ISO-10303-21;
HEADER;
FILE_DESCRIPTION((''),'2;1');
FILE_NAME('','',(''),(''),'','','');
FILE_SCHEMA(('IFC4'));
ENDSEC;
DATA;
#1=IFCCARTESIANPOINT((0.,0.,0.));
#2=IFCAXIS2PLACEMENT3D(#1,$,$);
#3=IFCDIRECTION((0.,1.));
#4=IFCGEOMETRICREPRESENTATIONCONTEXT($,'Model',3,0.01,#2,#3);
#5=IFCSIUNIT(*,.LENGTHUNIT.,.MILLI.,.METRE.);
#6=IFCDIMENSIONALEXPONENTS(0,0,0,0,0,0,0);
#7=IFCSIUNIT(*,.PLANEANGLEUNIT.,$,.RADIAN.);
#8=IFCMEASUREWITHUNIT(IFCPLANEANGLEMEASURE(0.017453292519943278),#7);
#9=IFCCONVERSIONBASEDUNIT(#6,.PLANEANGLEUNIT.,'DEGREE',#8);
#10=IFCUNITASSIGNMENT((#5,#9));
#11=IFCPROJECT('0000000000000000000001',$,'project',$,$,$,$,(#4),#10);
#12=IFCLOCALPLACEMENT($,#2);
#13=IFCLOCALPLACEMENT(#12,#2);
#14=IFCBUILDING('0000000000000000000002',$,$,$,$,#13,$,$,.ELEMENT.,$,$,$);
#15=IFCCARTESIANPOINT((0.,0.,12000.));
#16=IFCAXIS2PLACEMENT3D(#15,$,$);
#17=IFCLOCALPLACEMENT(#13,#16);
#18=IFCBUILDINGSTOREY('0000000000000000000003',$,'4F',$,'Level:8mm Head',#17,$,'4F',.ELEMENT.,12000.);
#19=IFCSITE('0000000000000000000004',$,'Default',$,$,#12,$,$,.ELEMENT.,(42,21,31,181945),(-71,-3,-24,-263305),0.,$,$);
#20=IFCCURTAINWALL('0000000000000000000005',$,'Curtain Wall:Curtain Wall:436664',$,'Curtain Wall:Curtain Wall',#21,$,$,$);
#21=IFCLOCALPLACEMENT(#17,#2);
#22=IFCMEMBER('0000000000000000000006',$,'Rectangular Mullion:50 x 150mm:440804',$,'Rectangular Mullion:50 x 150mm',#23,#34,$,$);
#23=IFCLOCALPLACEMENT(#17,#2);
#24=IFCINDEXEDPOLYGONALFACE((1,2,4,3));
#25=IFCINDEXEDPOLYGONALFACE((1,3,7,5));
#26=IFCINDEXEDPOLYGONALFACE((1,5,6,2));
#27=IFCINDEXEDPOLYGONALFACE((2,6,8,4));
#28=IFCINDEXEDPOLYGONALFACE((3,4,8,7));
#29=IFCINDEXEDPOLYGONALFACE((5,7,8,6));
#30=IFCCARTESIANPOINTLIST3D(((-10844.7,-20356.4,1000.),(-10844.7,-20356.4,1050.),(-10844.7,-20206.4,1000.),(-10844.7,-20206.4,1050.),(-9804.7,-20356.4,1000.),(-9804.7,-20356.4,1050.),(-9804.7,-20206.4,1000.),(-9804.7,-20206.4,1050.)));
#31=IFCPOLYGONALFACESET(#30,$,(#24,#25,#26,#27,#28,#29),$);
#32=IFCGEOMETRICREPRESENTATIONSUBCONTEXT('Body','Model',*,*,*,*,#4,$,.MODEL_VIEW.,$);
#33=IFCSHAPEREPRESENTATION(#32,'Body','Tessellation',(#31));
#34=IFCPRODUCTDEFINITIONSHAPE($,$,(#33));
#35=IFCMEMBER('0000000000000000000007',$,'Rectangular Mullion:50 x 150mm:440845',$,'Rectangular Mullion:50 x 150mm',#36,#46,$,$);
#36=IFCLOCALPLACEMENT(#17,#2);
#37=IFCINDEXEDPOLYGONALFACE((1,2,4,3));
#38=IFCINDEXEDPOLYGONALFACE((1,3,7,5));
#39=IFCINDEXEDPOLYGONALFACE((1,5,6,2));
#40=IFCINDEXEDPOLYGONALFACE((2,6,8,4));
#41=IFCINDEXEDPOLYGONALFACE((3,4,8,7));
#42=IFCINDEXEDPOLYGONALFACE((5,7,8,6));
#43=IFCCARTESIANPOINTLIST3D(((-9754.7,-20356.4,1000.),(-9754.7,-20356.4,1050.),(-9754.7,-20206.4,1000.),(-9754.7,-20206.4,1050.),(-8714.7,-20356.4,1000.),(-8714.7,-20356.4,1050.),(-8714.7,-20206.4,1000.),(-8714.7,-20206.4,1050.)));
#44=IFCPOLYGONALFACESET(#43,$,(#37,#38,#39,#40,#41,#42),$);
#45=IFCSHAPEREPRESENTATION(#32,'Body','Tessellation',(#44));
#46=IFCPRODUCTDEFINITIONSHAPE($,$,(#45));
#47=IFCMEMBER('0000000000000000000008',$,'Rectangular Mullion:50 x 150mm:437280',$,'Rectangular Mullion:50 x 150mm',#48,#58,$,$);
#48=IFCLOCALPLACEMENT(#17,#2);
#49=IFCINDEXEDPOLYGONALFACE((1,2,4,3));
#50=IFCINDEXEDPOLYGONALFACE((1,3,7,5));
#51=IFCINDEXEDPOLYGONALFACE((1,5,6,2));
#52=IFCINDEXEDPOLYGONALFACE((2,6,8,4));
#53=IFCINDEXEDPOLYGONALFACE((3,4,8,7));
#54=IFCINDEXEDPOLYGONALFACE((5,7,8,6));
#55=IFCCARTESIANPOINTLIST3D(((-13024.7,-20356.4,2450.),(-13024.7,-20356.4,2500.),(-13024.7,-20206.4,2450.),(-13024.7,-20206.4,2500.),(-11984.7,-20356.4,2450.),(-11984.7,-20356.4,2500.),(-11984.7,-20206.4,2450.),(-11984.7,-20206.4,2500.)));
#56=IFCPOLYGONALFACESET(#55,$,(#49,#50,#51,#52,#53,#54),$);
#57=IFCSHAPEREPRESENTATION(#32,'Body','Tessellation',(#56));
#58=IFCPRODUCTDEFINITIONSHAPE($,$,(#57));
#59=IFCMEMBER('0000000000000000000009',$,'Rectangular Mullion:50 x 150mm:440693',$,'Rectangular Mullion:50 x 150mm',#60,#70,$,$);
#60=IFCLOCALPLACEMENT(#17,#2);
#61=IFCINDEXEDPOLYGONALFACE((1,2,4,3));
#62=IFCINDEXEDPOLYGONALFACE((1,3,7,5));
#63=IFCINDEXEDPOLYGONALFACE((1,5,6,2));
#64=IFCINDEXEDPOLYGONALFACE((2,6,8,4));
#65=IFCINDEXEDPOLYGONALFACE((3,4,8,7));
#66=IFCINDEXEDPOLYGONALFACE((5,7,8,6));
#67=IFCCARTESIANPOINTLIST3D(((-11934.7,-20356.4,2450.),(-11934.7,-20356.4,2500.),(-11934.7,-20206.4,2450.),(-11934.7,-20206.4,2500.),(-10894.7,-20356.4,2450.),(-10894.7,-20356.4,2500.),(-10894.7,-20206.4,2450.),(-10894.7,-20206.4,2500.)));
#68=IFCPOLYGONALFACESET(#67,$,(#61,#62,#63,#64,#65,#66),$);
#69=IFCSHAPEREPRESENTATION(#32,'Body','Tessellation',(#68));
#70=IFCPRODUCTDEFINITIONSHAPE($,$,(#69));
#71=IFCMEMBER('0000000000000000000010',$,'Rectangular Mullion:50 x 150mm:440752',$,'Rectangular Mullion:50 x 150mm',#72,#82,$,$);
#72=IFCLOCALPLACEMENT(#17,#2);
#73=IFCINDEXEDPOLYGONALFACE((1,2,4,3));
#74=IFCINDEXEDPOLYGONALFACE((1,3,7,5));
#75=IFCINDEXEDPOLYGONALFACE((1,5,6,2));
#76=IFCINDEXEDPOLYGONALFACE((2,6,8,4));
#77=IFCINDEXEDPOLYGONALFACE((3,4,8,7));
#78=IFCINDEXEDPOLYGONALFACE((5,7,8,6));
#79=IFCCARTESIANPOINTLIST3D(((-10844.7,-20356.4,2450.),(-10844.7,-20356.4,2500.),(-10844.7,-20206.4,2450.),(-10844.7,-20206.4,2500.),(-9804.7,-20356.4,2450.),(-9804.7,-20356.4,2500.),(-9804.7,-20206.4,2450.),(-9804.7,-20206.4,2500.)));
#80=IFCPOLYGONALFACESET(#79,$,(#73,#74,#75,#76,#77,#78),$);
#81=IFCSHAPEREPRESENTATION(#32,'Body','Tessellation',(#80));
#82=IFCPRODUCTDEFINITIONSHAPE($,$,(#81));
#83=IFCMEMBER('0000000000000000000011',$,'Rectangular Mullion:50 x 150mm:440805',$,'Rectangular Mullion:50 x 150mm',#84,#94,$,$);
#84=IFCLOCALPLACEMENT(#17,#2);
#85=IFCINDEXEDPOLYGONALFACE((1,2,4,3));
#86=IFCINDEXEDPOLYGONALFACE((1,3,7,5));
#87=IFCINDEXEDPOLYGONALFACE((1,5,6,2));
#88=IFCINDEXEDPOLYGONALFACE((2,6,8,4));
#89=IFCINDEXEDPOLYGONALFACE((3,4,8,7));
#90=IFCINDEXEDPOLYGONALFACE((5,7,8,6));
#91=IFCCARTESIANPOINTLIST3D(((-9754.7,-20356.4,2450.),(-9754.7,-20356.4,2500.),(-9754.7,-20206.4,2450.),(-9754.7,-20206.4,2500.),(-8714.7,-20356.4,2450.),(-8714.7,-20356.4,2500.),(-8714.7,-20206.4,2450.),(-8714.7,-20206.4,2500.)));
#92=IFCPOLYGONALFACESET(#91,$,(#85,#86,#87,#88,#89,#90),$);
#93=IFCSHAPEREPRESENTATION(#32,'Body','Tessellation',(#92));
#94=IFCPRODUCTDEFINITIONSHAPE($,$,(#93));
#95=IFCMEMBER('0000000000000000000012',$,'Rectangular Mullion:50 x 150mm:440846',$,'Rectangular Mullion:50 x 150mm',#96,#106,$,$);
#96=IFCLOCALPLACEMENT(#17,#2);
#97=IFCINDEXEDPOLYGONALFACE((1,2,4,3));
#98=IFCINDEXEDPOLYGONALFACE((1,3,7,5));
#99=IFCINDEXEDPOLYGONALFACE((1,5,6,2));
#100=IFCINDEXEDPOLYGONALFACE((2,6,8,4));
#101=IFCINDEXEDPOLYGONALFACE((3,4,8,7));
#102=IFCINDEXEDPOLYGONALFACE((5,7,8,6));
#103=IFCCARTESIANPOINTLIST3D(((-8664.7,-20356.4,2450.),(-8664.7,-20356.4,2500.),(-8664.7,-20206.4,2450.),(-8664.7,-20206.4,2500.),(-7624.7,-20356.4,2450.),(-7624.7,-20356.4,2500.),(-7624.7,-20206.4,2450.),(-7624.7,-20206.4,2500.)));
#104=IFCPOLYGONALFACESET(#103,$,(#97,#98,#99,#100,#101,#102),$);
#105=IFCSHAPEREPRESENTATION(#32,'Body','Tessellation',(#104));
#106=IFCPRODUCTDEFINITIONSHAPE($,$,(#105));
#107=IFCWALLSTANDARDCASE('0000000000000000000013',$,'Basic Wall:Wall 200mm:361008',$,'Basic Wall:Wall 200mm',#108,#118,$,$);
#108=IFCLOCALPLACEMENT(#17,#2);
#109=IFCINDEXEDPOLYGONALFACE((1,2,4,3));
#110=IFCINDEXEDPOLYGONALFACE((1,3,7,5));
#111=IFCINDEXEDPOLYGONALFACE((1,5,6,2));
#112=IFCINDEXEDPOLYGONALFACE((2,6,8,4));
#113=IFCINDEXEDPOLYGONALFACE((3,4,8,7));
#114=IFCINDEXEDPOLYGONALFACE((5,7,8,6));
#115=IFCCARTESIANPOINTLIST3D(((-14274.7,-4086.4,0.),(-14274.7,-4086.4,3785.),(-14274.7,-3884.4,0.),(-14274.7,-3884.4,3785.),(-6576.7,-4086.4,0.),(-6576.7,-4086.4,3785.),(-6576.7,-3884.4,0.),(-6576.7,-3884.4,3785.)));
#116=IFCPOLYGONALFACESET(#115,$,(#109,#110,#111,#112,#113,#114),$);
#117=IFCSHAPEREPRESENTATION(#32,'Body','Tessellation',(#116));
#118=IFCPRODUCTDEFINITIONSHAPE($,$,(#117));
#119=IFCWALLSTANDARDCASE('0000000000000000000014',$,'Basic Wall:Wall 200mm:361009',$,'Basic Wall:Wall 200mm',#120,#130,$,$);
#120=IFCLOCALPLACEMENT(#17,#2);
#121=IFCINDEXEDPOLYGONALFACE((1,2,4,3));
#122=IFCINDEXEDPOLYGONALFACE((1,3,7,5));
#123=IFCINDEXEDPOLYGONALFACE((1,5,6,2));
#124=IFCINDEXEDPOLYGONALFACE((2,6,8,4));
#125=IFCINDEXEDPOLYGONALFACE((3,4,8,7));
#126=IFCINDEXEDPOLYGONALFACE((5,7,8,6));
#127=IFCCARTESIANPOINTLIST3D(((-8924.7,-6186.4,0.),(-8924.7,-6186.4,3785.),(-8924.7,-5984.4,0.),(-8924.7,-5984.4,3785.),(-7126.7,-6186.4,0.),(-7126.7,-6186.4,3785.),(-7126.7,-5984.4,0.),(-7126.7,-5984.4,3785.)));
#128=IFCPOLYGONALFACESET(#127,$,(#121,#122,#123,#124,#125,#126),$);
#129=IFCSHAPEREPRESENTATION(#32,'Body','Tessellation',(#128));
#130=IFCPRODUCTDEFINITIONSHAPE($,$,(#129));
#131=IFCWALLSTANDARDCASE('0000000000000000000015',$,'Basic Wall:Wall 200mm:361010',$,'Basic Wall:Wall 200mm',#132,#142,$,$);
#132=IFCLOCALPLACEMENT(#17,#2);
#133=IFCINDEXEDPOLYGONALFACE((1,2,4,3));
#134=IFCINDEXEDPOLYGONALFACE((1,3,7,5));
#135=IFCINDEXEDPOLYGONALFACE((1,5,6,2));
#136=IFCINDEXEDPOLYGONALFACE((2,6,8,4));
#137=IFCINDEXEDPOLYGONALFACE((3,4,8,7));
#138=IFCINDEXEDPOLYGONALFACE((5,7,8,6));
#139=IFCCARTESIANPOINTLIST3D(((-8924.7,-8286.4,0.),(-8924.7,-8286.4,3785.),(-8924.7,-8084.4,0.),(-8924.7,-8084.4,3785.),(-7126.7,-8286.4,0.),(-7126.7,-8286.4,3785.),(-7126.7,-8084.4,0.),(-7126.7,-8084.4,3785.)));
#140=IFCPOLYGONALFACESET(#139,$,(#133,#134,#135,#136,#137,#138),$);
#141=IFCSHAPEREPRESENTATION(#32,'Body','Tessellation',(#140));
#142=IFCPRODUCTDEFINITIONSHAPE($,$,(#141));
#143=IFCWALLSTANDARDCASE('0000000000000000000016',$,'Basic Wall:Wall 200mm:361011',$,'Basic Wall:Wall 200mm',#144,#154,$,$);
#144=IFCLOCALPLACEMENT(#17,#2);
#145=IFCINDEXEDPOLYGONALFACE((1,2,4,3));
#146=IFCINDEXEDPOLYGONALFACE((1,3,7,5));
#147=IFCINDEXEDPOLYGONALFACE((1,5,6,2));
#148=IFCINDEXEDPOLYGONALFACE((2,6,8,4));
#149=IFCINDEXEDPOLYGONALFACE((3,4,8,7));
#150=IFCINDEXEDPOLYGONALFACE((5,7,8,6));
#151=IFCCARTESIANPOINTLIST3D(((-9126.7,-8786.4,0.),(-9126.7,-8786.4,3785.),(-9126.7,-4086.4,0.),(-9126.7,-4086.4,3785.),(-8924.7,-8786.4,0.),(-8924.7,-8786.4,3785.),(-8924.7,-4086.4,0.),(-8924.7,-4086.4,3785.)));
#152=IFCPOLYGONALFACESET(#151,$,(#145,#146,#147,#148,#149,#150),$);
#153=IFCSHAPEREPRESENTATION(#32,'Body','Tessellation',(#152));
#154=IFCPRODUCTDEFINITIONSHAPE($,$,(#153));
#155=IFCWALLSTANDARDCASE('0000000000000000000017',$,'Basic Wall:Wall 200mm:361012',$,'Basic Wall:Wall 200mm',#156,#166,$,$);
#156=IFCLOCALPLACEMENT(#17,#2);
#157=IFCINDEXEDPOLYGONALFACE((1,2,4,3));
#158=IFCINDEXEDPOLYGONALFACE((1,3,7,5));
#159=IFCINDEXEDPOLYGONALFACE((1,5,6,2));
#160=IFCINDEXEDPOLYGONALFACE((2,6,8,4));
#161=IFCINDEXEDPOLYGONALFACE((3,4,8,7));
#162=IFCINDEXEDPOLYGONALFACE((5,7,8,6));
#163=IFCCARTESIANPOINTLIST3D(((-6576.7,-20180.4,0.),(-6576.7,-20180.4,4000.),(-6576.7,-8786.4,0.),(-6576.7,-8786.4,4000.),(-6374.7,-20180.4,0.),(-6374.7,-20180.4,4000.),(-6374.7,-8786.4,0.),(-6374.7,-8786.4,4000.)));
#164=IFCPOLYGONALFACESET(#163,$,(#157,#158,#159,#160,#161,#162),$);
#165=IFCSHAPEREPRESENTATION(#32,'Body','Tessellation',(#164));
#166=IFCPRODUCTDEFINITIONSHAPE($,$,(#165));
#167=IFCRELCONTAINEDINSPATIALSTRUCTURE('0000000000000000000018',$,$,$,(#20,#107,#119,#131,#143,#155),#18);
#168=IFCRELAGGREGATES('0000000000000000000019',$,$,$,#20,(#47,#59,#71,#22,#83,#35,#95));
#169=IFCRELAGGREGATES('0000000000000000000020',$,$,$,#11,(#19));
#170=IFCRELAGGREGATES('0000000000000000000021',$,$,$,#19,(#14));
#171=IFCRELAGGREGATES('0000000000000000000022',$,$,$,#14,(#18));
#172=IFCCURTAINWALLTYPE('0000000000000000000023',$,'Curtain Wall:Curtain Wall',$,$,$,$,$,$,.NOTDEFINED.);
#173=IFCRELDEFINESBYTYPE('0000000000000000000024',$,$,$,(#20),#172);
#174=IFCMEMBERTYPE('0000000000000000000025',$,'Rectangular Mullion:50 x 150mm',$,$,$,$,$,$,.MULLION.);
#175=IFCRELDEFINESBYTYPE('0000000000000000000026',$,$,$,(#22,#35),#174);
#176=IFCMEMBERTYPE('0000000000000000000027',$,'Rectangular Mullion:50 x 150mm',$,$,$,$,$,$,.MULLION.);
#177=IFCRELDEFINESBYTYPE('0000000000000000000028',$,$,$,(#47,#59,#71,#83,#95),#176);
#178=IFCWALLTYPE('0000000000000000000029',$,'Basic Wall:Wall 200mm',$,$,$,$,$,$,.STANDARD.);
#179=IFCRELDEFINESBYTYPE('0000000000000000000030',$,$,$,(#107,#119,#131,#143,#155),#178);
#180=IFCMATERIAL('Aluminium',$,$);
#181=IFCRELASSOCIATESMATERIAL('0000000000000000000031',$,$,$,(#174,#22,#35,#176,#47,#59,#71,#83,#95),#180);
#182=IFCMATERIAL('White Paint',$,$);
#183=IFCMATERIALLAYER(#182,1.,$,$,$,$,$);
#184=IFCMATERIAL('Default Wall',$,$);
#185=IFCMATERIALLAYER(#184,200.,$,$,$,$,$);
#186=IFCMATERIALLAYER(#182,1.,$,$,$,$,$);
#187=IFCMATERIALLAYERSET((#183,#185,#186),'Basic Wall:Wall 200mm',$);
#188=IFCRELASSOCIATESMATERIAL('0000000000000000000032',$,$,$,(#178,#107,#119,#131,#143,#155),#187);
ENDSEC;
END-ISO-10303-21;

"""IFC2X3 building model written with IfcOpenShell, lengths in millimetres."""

from ifc_helpers import new_model, entity, si_unit, converted_unit, direction, frame, frame_2d, origin, origin_2d_with_axis, place, context, subcontext, project, spatial, polyline, rectangle, extrude, clip, bounded_halfspace, source, transform, mapped, material, layer, layer_set, layer_usage, type_object, type_shapes, element, aggregate, save


model = new_model("IFC2X3")

# Units and contexts
model_context = context("Model", 3, precision=0.01, world=origin(), true_north=direction((0.0, 1.0)))
body_context = subcontext(model_context, "Body", "Model", "MODEL_VIEW")
ifc_project = project(units=[si_unit("LENGTHUNIT", "METRE", prefix="MILLI"), converted_unit("PLANEANGLEUNIT", "DEGREE", entity("IfcPlaneAngleMeasure", 0.017453292519943278), si_unit("PLANEANGLEUNIT", "RADIAN"), dimensions=[0, 0, 0, 0, 0, 0, 0])], contexts=[model_context])

# Site, building, storey
site_placement = place(None, origin())
site = spatial("IfcSite", under=ifc_project, at=site_placement, Name="Default", CompositionType="ELEMENT", RefLatitude=(42, 21, 31, 181945), RefLongitude=(-71, -3, -24, -263305), RefElevation=0.0)
building_placement = place(site_placement, origin())
building = spatial("IfcBuilding", under=site, at=building_placement, CompositionType="ELEMENT")
storey_placement = place(building_placement, frame((0.0, 0.0, 12000.0)))
storey = spatial("IfcBuildingStorey", under=building, at=storey_placement, Name="4F", ObjectType="Level:8mm Head", LongName="4F", CompositionType="ELEMENT", Elevation=12000.0)

# Curtain wall, members
curtain_wall_type = type_object("IfcCurtainWallType", Name="Curtain Wall:Curtain Wall", PredefinedType="NOTDEFINED")
curtain_wall_placement = place(storey_placement, frame((0.0, 0.0, -12000.0)))
curtain_wall = element("IfcCurtainWall", 1, at=curtain_wall_placement, inside=storey, type_object=curtain_wall_type, Name="Curtain Wall:Curtain Wall:436664", ObjectType="Curtain Wall:Curtain Wall")
ifc_material_1 = material(Name="Aluminium")
member_type_1 = type_object("IfcMemberType", Name="Rectangular Mullion:50 x 150mm", PredefinedType="MULLION", material=ifc_material_1)
shared_shape_1 = source(origin(), body_context, "Body", "SweptSolid", [
    extrude(rectangle(XDim=50.0, YDim=150.0, at=origin_2d_with_axis()), frame((-25.0, 0.0, -1040.0), z_axis=(0.0, 0.0, 1.0), x_axis=(-1.0, 0.0, 0.0)), (0.0, 0.0, 1.0), 1040.0),
])
type_shapes(member_type_1, [shared_shape_1])
member_1_placement = place(curtain_wall_placement, frame((-9804.7, -20281.4, 13000.0), z_axis=(1.0, 0.0, 0.0), x_axis=(0.0, 0.0, -1.0)))
member_1 = element("IfcMember", 2, at=member_1_placement, type_object=member_type_1, material=ifc_material_1, Name="Rectangular Mullion:50 x 150mm:440804", ObjectType="Rectangular Mullion:50 x 150mm", context=body_context, shape_type="MappedRepresentation", body=[
    mapped(shared_shape_1, transform((0.0, 0.0, 0.0), scale=1.0)),
])
member_2_placement = place(curtain_wall_placement, frame((-8714.7, -20281.4, 13000.0), z_axis=(1.0, 0.0, 0.0), x_axis=(0.0, 0.0, -1.0)))
member_2 = element("IfcMember", 3, at=member_2_placement, type_object=member_type_1, material=ifc_material_1, Name="Rectangular Mullion:50 x 150mm:440845", ObjectType="Rectangular Mullion:50 x 150mm", context=body_context, shape_type="MappedRepresentation", body=[
    mapped(shared_shape_1, transform((0.0, 0.0, 0.0), scale=1.0)),
])
member_type_2 = type_object("IfcMemberType", Name="Rectangular Mullion:50 x 150mm", PredefinedType="MULLION", material=ifc_material_1)
shared_shape_2 = source(origin(), body_context, "Body", "SweptSolid", [
    extrude(rectangle(XDim=50.0, YDim=150.0, at=origin_2d_with_axis()), frame((-25.0, 0.0, -1040.0), z_axis=(0.0, 0.0, 1.0), x_axis=(-1.0, 0.0, 0.0)), (0.0, 0.0, 1.0), 1040.0),
])
type_shapes(member_type_2, [shared_shape_2])
member_3_placement = place(curtain_wall_placement, frame((-13024.7, -20281.4, 14500.0), z_axis=(-1.0, 0.0, 0.0), x_axis=(0.0, 0.0, 1.0)))
member_3 = element("IfcMember", 4, at=member_3_placement, type_object=member_type_2, material=ifc_material_1, Name="Rectangular Mullion:50 x 150mm:437280", ObjectType="Rectangular Mullion:50 x 150mm", context=body_context, shape_type="MappedRepresentation", body=[
    mapped(shared_shape_2, transform((0.0, 0.0, 0.0), scale=1.0)),
])
member_4_placement = place(curtain_wall_placement, frame((-11934.7, -20281.4, 14500.0), z_axis=(-1.0, 0.0, 0.0), x_axis=(0.0, 0.0, 1.0)))
member_4 = element("IfcMember", 5, at=member_4_placement, type_object=member_type_2, material=ifc_material_1, Name="Rectangular Mullion:50 x 150mm:440693", ObjectType="Rectangular Mullion:50 x 150mm", context=body_context, shape_type="MappedRepresentation", body=[
    mapped(shared_shape_2, transform((0.0, 0.0, 0.0), scale=1.0)),
])
member_5_placement = place(curtain_wall_placement, frame((-10844.7, -20281.4, 14500.0), z_axis=(-1.0, 0.0, 0.0), x_axis=(0.0, 0.0, 1.0)))
member_5 = element("IfcMember", 6, at=member_5_placement, type_object=member_type_2, material=ifc_material_1, Name="Rectangular Mullion:50 x 150mm:440752", ObjectType="Rectangular Mullion:50 x 150mm", context=body_context, shape_type="MappedRepresentation", body=[
    mapped(shared_shape_2, transform((0.0, 0.0, 0.0), scale=1.0)),
])
member_6_placement = place(curtain_wall_placement, frame((-9754.7, -20281.4, 14500.0), z_axis=(-1.0, 0.0, 0.0), x_axis=(0.0, 0.0, 1.0)))
member_6 = element("IfcMember", 7, at=member_6_placement, type_object=member_type_2, material=ifc_material_1, Name="Rectangular Mullion:50 x 150mm:440805", ObjectType="Rectangular Mullion:50 x 150mm", context=body_context, shape_type="MappedRepresentation", body=[
    mapped(shared_shape_2, transform((0.0, 0.0, 0.0), scale=1.0)),
])
member_7_placement = place(curtain_wall_placement, frame((-8664.7, -20281.4, 14500.0), z_axis=(-1.0, 0.0, 0.0), x_axis=(0.0, 0.0, 1.0)))
member_7 = element("IfcMember", 8, at=member_7_placement, type_object=member_type_2, material=ifc_material_1, Name="Rectangular Mullion:50 x 150mm:440846", ObjectType="Rectangular Mullion:50 x 150mm", context=body_context, shape_type="MappedRepresentation", body=[
    mapped(shared_shape_2, transform((0.0, 0.0, 0.0), scale=1.0)),
])
aggregate(curtain_wall, [member_3, member_4, member_5, member_1, member_6, member_2, member_7])

# Walls
ifc_material_2 = material(Name="White Paint")
ifc_layer_1 = layer(ifc_material_2, 1.0)
ifc_material_3 = material(Name="Default Wall")
ifc_layer_2 = layer(ifc_material_3, 200.0)
ifc_layer_3 = layer(ifc_material_2, 1.0)
ifc_layer_set = layer_set([ifc_layer_1, ifc_layer_2, ifc_layer_3], Name="Basic Wall:Wall 200mm")
ifc_layer_usage_1 = layer_usage(ifc_layer_set, "AXIS2", "NEGATIVE", 101.0)
wall_type = type_object("IfcWallType", Name="Basic Wall:Wall 200mm", PredefinedType="STANDARD", material=ifc_layer_set)
wall_1_placement = place(storey_placement, frame((-6576.7, -3985.4, 0.0), z_axis=(0.0, 0.0, 1.0), x_axis=(-1.0, 0.0, 0.0)))
element("IfcWallStandardCase", 9, at=wall_1_placement, inside=storey, type_object=wall_type, material=ifc_layer_usage_1, Name="Basic Wall:Wall 200mm:361008", ObjectType="Basic Wall:Wall 200mm", context=body_context, shape_type="Clipping", body=[
    clip(extrude(rectangle(XDim=7698.0, YDim=202.0, at=frame_2d((3849.0, 0.0), x_axis=(-1.0, 0.0))), origin(), (0.0, 0.0, 1.0), 3785.0), bounded_halfspace(frame((0.0, -101.0, 3785.0), z_axis=(0.0, 0.0, -1.0), x_axis=(0.0, 1.0, 0.0)), True, frame((0.0, -101.0, 3785.0), z_axis=(0.0, 0.0, -1.0), x_axis=(0.0, 1.0, 0.0)), polyline([(0.0, 0.0), (202.0, 0.0), (202.0, 348.0), (202.0, 550.0), (202.0, 2348.0), (202.0, 2550.0), (202.0, 7698.0), (0.0, 7698.0), (0.0, 7496.0), (0.0, 0.0)]))),
])
ifc_layer_usage_2 = layer_usage(ifc_layer_set, "AXIS2", "NEGATIVE", 101.0)
wall_2_placement = place(storey_placement, frame((-7126.7, -6085.4, 0.0), z_axis=(0.0, 0.0, 1.0), x_axis=(-1.0, 0.0, 0.0)))
element("IfcWallStandardCase", 10, at=wall_2_placement, inside=storey, type_object=wall_type, material=ifc_layer_usage_2, Name="Basic Wall:Wall 200mm:361009", ObjectType="Basic Wall:Wall 200mm", context=body_context, shape_type="Clipping", body=[
    clip(extrude(rectangle(XDim=1798.0, YDim=202.0, at=frame_2d((899.0, 0.0), x_axis=(-1.0, 0.0))), origin(), (0.0, 0.0, 1.0), 3785.0), bounded_halfspace(frame((0.0, -101.0, 3785.0), z_axis=(0.0, 0.0, -1.0), x_axis=(0.0, 1.0, 0.0)), True, frame((0.0, -101.0, 3785.0), z_axis=(0.0, 0.0, -1.0), x_axis=(0.0, 1.0, 0.0)), polyline([(0.0, 0.0), (202.0, 0.0), (202.0, 1798.0), (0.0, 1798.0), (0.0, 0.0)]))),
])
ifc_layer_usage_3 = layer_usage(ifc_layer_set, "AXIS2", "NEGATIVE", 101.0)
wall_3_placement = place(storey_placement, frame((-7126.7, -8185.4, 0.0), z_axis=(0.0, 0.0, 1.0), x_axis=(-1.0, 0.0, 0.0)))
element("IfcWallStandardCase", 11, at=wall_3_placement, inside=storey, type_object=wall_type, material=ifc_layer_usage_3, Name="Basic Wall:Wall 200mm:361010", ObjectType="Basic Wall:Wall 200mm", context=body_context, shape_type="Clipping", body=[
    clip(extrude(rectangle(XDim=1798.0, YDim=202.0, at=frame_2d((899.0, 0.0), x_axis=(-1.0, 0.0))), origin(), (0.0, 0.0, 1.0), 3785.0), bounded_halfspace(frame((0.0, -101.0, 3785.0), z_axis=(0.0, 0.0, -1.0), x_axis=(0.0, 1.0, 0.0)), True, frame((0.0, -101.0, 3785.0), z_axis=(0.0, 0.0, -1.0), x_axis=(0.0, 1.0, 0.0)), polyline([(0.0, 0.0), (202.0, 0.0), (202.0, 1798.0), (0.0, 1798.0), (0.0, 0.0)]))),
])
ifc_layer_usage_4 = layer_usage(ifc_layer_set, "AXIS2", "NEGATIVE", 101.0)
wall_4_placement = place(storey_placement, frame((-9025.7, -4086.4, 0.0), z_axis=(0.0, 0.0, 1.0), x_axis=(0.0, -1.0, 0.0)))
element("IfcWallStandardCase", 12, at=wall_4_placement, inside=storey, type_object=wall_type, material=ifc_layer_usage_4, Name="Basic Wall:Wall 200mm:361011", ObjectType="Basic Wall:Wall 200mm", context=body_context, shape_type="Clipping", body=[
    clip(extrude(rectangle(XDim=4700.0, YDim=202.0, at=frame_2d((2350.0, 0.0), x_axis=(-1.0, 0.0))), origin(), (0.0, 0.0, 1.0), 3785.0), bounded_halfspace(frame((0.0, -101.0, 3785.0), z_axis=(0.0, 0.0, -1.0), x_axis=(1.0, 0.0, 0.0)), True, frame((0.0, -101.0, 3785.0), z_axis=(0.0, 0.0, -1.0), x_axis=(1.0, 0.0, 0.0)), polyline([(0.0, 0.0), (0.0, -202.0), (1898.0, -202.0), (2100.0, -202.0), (3998.0, -202.0), (4200.0, -202.0), (4498.0, -202.0), (4700.0, -202.0), (4700.0, 0.0), (0.0, 0.0)]))),
])
ifc_layer_usage_5 = layer_usage(ifc_layer_set, "AXIS2", "NEGATIVE", 101.0)
wall_5_placement = place(storey_placement, frame((-6475.7, -8786.4, 0.0), z_axis=(0.0, 0.0, 1.0), x_axis=(0.0, -1.0, 0.0)))
element("IfcWallStandardCase", 13, at=wall_5_placement, inside=storey, type_object=wall_type, material=ifc_layer_usage_5, Name="Basic Wall:Wall 200mm:361012", ObjectType="Basic Wall:Wall 200mm", context=body_context, shape_type="SweptSolid", body=[
    extrude(rectangle(XDim=11394.0, YDim=202.0, at=frame_2d((5697.0, 0.0), x_axis=(-1.0, 0.0))), origin(), (0.0, 0.0, 1.0), 4000.0),
])

save(model, "model.ifc")
